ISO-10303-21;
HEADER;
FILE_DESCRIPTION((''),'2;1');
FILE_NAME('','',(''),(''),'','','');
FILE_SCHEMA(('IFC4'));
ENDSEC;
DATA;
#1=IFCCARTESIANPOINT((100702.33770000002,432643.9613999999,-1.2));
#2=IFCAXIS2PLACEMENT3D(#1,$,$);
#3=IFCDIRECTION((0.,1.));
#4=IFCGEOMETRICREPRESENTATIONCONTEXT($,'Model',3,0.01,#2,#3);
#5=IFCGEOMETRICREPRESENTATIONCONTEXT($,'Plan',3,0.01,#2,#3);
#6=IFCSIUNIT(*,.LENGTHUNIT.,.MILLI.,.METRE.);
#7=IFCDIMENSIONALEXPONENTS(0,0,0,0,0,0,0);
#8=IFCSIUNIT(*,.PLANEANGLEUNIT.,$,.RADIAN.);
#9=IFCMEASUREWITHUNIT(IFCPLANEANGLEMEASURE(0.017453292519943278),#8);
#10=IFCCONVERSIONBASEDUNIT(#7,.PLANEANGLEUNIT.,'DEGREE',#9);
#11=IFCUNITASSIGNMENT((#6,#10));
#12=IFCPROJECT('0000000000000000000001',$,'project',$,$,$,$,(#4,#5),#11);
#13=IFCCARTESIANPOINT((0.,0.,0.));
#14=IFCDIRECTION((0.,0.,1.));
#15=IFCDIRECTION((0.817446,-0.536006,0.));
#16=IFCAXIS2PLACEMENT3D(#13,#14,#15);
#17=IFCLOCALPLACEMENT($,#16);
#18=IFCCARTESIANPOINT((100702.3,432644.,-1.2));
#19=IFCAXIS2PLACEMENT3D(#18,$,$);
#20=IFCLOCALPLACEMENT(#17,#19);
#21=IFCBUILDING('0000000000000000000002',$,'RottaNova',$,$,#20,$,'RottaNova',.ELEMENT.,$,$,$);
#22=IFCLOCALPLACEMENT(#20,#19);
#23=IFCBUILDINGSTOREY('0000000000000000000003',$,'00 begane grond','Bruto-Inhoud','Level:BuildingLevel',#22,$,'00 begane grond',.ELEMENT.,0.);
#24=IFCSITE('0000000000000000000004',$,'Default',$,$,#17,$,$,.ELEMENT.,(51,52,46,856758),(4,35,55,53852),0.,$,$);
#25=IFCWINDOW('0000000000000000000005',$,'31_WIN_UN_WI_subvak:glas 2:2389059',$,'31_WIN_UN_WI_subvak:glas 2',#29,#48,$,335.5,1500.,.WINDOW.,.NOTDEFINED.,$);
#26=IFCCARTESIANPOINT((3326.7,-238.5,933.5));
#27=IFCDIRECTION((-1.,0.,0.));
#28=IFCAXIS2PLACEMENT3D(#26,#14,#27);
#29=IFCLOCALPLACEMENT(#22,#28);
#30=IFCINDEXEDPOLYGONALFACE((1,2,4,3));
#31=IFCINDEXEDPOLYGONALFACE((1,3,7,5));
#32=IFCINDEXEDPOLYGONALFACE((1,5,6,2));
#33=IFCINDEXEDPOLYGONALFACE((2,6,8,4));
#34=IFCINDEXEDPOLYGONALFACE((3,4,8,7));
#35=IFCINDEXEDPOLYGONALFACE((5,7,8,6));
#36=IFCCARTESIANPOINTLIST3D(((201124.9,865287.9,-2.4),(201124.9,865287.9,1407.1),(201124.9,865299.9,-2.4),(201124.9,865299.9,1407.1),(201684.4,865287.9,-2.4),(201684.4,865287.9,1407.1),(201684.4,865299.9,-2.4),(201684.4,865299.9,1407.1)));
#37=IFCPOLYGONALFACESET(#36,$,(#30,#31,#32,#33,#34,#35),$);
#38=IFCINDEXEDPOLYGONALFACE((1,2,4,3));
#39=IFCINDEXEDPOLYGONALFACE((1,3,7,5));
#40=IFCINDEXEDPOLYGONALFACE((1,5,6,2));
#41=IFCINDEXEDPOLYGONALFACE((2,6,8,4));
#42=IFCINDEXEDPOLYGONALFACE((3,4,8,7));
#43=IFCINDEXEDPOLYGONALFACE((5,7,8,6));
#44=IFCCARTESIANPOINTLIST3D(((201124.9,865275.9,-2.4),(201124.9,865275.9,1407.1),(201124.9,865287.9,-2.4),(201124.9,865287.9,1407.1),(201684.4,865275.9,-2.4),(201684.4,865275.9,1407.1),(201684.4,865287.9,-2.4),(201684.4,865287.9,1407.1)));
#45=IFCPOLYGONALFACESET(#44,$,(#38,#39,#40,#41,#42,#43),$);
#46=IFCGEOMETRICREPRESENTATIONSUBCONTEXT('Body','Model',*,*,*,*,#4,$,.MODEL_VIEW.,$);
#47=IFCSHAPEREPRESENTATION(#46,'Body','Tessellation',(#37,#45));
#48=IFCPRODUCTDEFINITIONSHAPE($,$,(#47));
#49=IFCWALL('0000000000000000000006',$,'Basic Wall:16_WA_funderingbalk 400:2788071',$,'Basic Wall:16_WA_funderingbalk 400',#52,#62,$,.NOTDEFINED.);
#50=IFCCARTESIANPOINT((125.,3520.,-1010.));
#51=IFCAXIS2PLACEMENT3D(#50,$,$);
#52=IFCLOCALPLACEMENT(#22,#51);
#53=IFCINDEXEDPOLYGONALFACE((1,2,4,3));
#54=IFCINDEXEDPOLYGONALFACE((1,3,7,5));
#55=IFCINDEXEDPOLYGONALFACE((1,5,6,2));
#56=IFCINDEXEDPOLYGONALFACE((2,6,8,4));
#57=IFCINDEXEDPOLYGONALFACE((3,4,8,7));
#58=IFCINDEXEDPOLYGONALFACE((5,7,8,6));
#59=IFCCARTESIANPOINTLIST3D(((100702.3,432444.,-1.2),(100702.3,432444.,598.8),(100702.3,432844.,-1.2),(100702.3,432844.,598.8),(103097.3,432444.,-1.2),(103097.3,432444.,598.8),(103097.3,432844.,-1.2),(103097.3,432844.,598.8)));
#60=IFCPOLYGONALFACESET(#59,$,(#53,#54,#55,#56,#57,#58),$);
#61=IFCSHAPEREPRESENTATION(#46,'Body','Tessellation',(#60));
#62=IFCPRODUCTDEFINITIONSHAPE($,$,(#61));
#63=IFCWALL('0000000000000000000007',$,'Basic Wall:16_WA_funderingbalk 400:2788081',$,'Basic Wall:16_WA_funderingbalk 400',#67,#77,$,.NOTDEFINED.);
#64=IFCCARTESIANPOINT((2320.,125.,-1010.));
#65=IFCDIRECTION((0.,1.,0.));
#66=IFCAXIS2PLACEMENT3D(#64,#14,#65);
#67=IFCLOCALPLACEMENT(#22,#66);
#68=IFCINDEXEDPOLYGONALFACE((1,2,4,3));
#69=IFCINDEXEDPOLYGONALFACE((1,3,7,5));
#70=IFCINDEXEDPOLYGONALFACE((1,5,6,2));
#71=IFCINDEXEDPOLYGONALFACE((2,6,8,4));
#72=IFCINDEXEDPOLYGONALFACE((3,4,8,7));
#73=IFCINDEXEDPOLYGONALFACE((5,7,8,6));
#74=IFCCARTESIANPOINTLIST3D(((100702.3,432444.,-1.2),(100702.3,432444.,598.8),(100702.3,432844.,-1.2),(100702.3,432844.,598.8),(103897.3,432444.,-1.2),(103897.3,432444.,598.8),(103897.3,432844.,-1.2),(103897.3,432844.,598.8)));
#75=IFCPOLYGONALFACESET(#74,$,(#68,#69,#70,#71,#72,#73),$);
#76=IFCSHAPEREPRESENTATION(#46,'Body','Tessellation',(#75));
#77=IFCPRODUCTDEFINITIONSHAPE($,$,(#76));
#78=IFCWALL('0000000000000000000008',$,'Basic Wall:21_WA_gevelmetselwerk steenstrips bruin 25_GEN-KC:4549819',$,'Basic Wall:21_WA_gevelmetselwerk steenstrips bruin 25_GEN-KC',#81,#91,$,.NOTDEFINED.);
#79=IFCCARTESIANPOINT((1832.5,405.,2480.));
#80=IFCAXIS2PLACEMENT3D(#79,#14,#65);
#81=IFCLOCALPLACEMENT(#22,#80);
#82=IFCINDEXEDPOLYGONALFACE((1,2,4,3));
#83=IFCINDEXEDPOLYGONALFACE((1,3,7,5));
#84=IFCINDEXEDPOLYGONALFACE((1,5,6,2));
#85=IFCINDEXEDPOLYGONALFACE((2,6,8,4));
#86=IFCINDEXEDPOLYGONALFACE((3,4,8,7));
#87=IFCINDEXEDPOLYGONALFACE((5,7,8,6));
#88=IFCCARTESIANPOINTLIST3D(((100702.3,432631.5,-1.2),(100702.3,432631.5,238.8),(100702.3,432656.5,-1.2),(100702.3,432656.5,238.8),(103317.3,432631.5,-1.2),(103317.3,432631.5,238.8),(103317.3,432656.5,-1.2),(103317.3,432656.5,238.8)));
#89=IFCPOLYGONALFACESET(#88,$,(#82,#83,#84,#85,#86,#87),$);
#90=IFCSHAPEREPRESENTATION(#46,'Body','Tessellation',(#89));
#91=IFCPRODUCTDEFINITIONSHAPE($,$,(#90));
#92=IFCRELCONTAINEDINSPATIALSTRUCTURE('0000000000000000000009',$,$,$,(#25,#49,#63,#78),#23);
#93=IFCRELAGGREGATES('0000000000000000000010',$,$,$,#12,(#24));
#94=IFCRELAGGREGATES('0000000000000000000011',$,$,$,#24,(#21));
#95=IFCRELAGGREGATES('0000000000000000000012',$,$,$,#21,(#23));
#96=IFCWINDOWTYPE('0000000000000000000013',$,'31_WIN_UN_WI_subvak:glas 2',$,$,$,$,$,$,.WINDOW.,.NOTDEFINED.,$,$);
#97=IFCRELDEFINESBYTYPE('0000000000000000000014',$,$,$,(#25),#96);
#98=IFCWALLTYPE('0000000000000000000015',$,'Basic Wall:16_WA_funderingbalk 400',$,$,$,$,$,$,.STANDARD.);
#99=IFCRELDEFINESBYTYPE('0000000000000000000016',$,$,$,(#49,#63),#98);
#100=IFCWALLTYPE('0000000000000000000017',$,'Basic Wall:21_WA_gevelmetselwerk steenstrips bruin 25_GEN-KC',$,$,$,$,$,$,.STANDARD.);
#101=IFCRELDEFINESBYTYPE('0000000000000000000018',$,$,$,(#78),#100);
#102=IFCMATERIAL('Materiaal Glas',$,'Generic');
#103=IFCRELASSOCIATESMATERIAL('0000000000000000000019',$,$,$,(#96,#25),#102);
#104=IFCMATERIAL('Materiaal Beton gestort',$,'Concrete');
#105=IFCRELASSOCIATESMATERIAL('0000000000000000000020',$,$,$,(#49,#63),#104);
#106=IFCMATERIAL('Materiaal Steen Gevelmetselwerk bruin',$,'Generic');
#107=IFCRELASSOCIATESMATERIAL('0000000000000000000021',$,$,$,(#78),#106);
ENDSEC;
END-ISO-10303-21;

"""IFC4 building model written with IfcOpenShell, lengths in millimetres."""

from ifc_helpers import new_model, entity, si_unit, converted_unit, direction, frame, place, context, subcontext, project, spatial, indexed_curve, outline, extrude, source, transform, mapped, material, type_object, type_shapes, element, save


model = new_model("IFC4")

# Units and contexts
model_context = context("Model", 3, precision=0.01, world=frame((100702.33770000002, 432643.9613999999, -1.2)), true_north=direction((0.0, 1.0)))
plan_context = context("Plan", 3, precision=0.01, world=frame((100702.33770000002, 432643.9613999999, -1.2)), true_north=direction((0.0, 1.0)))
body_context = subcontext(model_context, "Body", "Model", "MODEL_VIEW")
ifc_project = project(units=[si_unit("LENGTHUNIT", "METRE", prefix="MILLI"), converted_unit("PLANEANGLEUNIT", "DEGREE", entity("IfcPlaneAngleMeasure", 0.017453292519943278), si_unit("PLANEANGLEUNIT", "RADIAN"), dimensions=[0, 0, 0, 0, 0, 0, 0])], contexts=[model_context, plan_context])

# Site, building, storey
site_placement = place(None, frame((0.0, 0.0, 0.0), z_axis=(0.0, 0.0, 1.0), x_axis=(0.817446, -0.536006, 0.0)))
site = spatial("IfcSite", under=ifc_project, at=site_placement, Name="Default", CompositionType="ELEMENT", RefLatitude=(51, 52, 46, 856758), RefLongitude=(4, 35, 55, 53852), RefElevation=0.0)
building_placement = place(site_placement, frame((100702.3, 432644.0, -1.2)))
building = spatial("IfcBuilding", under=site, at=building_placement, Name="RottaNova", LongName="RottaNova", CompositionType="ELEMENT")
storey_placement = place(building_placement, frame((100702.3, 432644.0, -1.2)))
storey = spatial("IfcBuildingStorey", under=building, at=storey_placement, Name="00 begane grond", Description="Bruto-Inhoud", ObjectType="Level:BuildingLevel", LongName="00 begane grond", CompositionType="ELEMENT", Elevation=0.0)

# Shared definitions
ifc_material_1 = material(Name="Materiaal Steen Gevelmetselwerk bruin", Category="Generic")

# Window
ifc_material_2 = material(Name="Materiaal Glas", Category="Generic")
window_type_1 = type_object("IfcWindowType", Name="31_WIN_UN_WI_subvak:glas 2", PartitioningType="NOTDEFINED", PredefinedType="WINDOW", material=ifc_material_2)
shared_shape_1 = source(frame((100702.3, 432644.0, -1.2)), body_context, "Body", "SweptSolid", [
    extrude(outline(indexed_curve([(-6.0, -279.8), (6.0, -279.8), (6.0, 279.8), (-6.0, 279.8), (-6.0, -279.8)], self_intersect=False)), frame((0.0, 6.0, 0.0), z_axis=(0.0, 0.0, 1.0), x_axis=(0.0, -1.0, 0.0)), (0.0, 0.0, 1.0), 1409.5),
    extrude(outline(indexed_curve([(-6.0, -279.8), (6.0, -279.8), (6.0, 279.8), (-6.0, 279.8), (-6.0, -279.8)], self_intersect=False)), frame((0.0, -6.0, 0.0), z_axis=(0.0, 0.0, 1.0), x_axis=(0.0, -1.0, 0.0)), (0.0, 0.0, 1.0), 1409.5),
])
type_shapes(window_type_1, [shared_shape_1])
for number, where, z_axis, x_axis, name in (
    (1, (3326.7, -238.5, 933.5), (0.0, 0.0, 1.0), (-1.0, 0.0, 0.0), "31_WIN_UN_WI_subvak:glas 2:2389059"),
):
    element("IfcWindow", number, at=place(storey_placement, frame(where, z_axis=z_axis, x_axis=x_axis)), inside=storey, type_object=window_type_1, material=ifc_material_2, Name=name, ObjectType="31_WIN_UN_WI_subvak:glas 2", OverallHeight=335.5, OverallWidth=1500.0, PartitioningType="NOTDEFINED", PredefinedType="WINDOW", context=body_context, shape_type="MappedRepresentation", body=[
        mapped(shared_shape_1, transform((100702.3, 432644.0, -1.2), scale=1.0)),
    ])

# Walls
ifc_material_3 = material(Name="Materiaal Beton gestort", Category="Concrete")
wall_type_1 = type_object("IfcWallType", Name="Basic Wall:16_WA_funderingbalk 400", PredefinedType="STANDARD")
wall_1_placement = place(storey_placement, frame((125.0, 3520.0, -1010.0)))
element("IfcWall", 2, at=wall_1_placement, inside=storey, type_object=wall_type_1, material=ifc_material_3, Name="Basic Wall:16_WA_funderingbalk 400:2788071", ObjectType="Basic Wall:16_WA_funderingbalk 400", PredefinedType="NOTDEFINED", context=body_context, shape_type="SweptSolid", body=[
    extrude(outline(indexed_curve([(2395.0, 200.0), (0.0, 200.0), (0.0, -200.0), (2395.0, -200.0), (2395.0, 200.0)], self_intersect=False)), frame((100702.3, 432644.0, -1.2)), (0.0, 0.0, 1.0), 600.0),
])
wall_2_placement = place(storey_placement, frame((2320.0, 125.0, -1010.0), z_axis=(0.0, 0.0, 1.0), x_axis=(0.0, 1.0, 0.0)))
element("IfcWall", 3, at=wall_2_placement, inside=storey, type_object=wall_type_1, material=ifc_material_3, Name="Basic Wall:16_WA_funderingbalk 400:2788081", ObjectType="Basic Wall:16_WA_funderingbalk 400", PredefinedType="NOTDEFINED", context=body_context, shape_type="SweptSolid", body=[
    extrude(outline(indexed_curve([(3195.0, 200.0), (0.0, 200.0), (0.0, -200.0), (3195.0, -200.0), (3195.0, 200.0)], self_intersect=False)), frame((100702.3, 432644.0, -1.2)), (0.0, 0.0, 1.0), 600.0),
])
wall_type_2 = type_object("IfcWallType", Name="Basic Wall:21_WA_gevelmetselwerk steenstrips bruin 25_GEN-KC", PredefinedType="STANDARD")
wall_3_placement = place(storey_placement, frame((1832.5, 405.0, 2480.0), z_axis=(0.0, 0.0, 1.0), x_axis=(0.0, 1.0, 0.0)))
element("IfcWall", 4, at=wall_3_placement, inside=storey, type_object=wall_type_2, material=ifc_material_1, Name="Basic Wall:21_WA_gevelmetselwerk steenstrips bruin 25_GEN-KC:4549819", ObjectType="Basic Wall:21_WA_gevelmetselwerk steenstrips bruin 25_GEN-KC", PredefinedType="NOTDEFINED", context=body_context, shape_type="SweptSolid", body=[
    extrude(outline(indexed_curve([(2615.0, 12.5), (0.0, 12.5), (0.0, -12.5), (2615.0, -12.5), (2615.0, 12.5)], self_intersect=False)), frame((100702.3, 432644.0, -1.2)), (0.0, 0.0, 1.0), 240.0),
])

save(model, "model.ifc")
